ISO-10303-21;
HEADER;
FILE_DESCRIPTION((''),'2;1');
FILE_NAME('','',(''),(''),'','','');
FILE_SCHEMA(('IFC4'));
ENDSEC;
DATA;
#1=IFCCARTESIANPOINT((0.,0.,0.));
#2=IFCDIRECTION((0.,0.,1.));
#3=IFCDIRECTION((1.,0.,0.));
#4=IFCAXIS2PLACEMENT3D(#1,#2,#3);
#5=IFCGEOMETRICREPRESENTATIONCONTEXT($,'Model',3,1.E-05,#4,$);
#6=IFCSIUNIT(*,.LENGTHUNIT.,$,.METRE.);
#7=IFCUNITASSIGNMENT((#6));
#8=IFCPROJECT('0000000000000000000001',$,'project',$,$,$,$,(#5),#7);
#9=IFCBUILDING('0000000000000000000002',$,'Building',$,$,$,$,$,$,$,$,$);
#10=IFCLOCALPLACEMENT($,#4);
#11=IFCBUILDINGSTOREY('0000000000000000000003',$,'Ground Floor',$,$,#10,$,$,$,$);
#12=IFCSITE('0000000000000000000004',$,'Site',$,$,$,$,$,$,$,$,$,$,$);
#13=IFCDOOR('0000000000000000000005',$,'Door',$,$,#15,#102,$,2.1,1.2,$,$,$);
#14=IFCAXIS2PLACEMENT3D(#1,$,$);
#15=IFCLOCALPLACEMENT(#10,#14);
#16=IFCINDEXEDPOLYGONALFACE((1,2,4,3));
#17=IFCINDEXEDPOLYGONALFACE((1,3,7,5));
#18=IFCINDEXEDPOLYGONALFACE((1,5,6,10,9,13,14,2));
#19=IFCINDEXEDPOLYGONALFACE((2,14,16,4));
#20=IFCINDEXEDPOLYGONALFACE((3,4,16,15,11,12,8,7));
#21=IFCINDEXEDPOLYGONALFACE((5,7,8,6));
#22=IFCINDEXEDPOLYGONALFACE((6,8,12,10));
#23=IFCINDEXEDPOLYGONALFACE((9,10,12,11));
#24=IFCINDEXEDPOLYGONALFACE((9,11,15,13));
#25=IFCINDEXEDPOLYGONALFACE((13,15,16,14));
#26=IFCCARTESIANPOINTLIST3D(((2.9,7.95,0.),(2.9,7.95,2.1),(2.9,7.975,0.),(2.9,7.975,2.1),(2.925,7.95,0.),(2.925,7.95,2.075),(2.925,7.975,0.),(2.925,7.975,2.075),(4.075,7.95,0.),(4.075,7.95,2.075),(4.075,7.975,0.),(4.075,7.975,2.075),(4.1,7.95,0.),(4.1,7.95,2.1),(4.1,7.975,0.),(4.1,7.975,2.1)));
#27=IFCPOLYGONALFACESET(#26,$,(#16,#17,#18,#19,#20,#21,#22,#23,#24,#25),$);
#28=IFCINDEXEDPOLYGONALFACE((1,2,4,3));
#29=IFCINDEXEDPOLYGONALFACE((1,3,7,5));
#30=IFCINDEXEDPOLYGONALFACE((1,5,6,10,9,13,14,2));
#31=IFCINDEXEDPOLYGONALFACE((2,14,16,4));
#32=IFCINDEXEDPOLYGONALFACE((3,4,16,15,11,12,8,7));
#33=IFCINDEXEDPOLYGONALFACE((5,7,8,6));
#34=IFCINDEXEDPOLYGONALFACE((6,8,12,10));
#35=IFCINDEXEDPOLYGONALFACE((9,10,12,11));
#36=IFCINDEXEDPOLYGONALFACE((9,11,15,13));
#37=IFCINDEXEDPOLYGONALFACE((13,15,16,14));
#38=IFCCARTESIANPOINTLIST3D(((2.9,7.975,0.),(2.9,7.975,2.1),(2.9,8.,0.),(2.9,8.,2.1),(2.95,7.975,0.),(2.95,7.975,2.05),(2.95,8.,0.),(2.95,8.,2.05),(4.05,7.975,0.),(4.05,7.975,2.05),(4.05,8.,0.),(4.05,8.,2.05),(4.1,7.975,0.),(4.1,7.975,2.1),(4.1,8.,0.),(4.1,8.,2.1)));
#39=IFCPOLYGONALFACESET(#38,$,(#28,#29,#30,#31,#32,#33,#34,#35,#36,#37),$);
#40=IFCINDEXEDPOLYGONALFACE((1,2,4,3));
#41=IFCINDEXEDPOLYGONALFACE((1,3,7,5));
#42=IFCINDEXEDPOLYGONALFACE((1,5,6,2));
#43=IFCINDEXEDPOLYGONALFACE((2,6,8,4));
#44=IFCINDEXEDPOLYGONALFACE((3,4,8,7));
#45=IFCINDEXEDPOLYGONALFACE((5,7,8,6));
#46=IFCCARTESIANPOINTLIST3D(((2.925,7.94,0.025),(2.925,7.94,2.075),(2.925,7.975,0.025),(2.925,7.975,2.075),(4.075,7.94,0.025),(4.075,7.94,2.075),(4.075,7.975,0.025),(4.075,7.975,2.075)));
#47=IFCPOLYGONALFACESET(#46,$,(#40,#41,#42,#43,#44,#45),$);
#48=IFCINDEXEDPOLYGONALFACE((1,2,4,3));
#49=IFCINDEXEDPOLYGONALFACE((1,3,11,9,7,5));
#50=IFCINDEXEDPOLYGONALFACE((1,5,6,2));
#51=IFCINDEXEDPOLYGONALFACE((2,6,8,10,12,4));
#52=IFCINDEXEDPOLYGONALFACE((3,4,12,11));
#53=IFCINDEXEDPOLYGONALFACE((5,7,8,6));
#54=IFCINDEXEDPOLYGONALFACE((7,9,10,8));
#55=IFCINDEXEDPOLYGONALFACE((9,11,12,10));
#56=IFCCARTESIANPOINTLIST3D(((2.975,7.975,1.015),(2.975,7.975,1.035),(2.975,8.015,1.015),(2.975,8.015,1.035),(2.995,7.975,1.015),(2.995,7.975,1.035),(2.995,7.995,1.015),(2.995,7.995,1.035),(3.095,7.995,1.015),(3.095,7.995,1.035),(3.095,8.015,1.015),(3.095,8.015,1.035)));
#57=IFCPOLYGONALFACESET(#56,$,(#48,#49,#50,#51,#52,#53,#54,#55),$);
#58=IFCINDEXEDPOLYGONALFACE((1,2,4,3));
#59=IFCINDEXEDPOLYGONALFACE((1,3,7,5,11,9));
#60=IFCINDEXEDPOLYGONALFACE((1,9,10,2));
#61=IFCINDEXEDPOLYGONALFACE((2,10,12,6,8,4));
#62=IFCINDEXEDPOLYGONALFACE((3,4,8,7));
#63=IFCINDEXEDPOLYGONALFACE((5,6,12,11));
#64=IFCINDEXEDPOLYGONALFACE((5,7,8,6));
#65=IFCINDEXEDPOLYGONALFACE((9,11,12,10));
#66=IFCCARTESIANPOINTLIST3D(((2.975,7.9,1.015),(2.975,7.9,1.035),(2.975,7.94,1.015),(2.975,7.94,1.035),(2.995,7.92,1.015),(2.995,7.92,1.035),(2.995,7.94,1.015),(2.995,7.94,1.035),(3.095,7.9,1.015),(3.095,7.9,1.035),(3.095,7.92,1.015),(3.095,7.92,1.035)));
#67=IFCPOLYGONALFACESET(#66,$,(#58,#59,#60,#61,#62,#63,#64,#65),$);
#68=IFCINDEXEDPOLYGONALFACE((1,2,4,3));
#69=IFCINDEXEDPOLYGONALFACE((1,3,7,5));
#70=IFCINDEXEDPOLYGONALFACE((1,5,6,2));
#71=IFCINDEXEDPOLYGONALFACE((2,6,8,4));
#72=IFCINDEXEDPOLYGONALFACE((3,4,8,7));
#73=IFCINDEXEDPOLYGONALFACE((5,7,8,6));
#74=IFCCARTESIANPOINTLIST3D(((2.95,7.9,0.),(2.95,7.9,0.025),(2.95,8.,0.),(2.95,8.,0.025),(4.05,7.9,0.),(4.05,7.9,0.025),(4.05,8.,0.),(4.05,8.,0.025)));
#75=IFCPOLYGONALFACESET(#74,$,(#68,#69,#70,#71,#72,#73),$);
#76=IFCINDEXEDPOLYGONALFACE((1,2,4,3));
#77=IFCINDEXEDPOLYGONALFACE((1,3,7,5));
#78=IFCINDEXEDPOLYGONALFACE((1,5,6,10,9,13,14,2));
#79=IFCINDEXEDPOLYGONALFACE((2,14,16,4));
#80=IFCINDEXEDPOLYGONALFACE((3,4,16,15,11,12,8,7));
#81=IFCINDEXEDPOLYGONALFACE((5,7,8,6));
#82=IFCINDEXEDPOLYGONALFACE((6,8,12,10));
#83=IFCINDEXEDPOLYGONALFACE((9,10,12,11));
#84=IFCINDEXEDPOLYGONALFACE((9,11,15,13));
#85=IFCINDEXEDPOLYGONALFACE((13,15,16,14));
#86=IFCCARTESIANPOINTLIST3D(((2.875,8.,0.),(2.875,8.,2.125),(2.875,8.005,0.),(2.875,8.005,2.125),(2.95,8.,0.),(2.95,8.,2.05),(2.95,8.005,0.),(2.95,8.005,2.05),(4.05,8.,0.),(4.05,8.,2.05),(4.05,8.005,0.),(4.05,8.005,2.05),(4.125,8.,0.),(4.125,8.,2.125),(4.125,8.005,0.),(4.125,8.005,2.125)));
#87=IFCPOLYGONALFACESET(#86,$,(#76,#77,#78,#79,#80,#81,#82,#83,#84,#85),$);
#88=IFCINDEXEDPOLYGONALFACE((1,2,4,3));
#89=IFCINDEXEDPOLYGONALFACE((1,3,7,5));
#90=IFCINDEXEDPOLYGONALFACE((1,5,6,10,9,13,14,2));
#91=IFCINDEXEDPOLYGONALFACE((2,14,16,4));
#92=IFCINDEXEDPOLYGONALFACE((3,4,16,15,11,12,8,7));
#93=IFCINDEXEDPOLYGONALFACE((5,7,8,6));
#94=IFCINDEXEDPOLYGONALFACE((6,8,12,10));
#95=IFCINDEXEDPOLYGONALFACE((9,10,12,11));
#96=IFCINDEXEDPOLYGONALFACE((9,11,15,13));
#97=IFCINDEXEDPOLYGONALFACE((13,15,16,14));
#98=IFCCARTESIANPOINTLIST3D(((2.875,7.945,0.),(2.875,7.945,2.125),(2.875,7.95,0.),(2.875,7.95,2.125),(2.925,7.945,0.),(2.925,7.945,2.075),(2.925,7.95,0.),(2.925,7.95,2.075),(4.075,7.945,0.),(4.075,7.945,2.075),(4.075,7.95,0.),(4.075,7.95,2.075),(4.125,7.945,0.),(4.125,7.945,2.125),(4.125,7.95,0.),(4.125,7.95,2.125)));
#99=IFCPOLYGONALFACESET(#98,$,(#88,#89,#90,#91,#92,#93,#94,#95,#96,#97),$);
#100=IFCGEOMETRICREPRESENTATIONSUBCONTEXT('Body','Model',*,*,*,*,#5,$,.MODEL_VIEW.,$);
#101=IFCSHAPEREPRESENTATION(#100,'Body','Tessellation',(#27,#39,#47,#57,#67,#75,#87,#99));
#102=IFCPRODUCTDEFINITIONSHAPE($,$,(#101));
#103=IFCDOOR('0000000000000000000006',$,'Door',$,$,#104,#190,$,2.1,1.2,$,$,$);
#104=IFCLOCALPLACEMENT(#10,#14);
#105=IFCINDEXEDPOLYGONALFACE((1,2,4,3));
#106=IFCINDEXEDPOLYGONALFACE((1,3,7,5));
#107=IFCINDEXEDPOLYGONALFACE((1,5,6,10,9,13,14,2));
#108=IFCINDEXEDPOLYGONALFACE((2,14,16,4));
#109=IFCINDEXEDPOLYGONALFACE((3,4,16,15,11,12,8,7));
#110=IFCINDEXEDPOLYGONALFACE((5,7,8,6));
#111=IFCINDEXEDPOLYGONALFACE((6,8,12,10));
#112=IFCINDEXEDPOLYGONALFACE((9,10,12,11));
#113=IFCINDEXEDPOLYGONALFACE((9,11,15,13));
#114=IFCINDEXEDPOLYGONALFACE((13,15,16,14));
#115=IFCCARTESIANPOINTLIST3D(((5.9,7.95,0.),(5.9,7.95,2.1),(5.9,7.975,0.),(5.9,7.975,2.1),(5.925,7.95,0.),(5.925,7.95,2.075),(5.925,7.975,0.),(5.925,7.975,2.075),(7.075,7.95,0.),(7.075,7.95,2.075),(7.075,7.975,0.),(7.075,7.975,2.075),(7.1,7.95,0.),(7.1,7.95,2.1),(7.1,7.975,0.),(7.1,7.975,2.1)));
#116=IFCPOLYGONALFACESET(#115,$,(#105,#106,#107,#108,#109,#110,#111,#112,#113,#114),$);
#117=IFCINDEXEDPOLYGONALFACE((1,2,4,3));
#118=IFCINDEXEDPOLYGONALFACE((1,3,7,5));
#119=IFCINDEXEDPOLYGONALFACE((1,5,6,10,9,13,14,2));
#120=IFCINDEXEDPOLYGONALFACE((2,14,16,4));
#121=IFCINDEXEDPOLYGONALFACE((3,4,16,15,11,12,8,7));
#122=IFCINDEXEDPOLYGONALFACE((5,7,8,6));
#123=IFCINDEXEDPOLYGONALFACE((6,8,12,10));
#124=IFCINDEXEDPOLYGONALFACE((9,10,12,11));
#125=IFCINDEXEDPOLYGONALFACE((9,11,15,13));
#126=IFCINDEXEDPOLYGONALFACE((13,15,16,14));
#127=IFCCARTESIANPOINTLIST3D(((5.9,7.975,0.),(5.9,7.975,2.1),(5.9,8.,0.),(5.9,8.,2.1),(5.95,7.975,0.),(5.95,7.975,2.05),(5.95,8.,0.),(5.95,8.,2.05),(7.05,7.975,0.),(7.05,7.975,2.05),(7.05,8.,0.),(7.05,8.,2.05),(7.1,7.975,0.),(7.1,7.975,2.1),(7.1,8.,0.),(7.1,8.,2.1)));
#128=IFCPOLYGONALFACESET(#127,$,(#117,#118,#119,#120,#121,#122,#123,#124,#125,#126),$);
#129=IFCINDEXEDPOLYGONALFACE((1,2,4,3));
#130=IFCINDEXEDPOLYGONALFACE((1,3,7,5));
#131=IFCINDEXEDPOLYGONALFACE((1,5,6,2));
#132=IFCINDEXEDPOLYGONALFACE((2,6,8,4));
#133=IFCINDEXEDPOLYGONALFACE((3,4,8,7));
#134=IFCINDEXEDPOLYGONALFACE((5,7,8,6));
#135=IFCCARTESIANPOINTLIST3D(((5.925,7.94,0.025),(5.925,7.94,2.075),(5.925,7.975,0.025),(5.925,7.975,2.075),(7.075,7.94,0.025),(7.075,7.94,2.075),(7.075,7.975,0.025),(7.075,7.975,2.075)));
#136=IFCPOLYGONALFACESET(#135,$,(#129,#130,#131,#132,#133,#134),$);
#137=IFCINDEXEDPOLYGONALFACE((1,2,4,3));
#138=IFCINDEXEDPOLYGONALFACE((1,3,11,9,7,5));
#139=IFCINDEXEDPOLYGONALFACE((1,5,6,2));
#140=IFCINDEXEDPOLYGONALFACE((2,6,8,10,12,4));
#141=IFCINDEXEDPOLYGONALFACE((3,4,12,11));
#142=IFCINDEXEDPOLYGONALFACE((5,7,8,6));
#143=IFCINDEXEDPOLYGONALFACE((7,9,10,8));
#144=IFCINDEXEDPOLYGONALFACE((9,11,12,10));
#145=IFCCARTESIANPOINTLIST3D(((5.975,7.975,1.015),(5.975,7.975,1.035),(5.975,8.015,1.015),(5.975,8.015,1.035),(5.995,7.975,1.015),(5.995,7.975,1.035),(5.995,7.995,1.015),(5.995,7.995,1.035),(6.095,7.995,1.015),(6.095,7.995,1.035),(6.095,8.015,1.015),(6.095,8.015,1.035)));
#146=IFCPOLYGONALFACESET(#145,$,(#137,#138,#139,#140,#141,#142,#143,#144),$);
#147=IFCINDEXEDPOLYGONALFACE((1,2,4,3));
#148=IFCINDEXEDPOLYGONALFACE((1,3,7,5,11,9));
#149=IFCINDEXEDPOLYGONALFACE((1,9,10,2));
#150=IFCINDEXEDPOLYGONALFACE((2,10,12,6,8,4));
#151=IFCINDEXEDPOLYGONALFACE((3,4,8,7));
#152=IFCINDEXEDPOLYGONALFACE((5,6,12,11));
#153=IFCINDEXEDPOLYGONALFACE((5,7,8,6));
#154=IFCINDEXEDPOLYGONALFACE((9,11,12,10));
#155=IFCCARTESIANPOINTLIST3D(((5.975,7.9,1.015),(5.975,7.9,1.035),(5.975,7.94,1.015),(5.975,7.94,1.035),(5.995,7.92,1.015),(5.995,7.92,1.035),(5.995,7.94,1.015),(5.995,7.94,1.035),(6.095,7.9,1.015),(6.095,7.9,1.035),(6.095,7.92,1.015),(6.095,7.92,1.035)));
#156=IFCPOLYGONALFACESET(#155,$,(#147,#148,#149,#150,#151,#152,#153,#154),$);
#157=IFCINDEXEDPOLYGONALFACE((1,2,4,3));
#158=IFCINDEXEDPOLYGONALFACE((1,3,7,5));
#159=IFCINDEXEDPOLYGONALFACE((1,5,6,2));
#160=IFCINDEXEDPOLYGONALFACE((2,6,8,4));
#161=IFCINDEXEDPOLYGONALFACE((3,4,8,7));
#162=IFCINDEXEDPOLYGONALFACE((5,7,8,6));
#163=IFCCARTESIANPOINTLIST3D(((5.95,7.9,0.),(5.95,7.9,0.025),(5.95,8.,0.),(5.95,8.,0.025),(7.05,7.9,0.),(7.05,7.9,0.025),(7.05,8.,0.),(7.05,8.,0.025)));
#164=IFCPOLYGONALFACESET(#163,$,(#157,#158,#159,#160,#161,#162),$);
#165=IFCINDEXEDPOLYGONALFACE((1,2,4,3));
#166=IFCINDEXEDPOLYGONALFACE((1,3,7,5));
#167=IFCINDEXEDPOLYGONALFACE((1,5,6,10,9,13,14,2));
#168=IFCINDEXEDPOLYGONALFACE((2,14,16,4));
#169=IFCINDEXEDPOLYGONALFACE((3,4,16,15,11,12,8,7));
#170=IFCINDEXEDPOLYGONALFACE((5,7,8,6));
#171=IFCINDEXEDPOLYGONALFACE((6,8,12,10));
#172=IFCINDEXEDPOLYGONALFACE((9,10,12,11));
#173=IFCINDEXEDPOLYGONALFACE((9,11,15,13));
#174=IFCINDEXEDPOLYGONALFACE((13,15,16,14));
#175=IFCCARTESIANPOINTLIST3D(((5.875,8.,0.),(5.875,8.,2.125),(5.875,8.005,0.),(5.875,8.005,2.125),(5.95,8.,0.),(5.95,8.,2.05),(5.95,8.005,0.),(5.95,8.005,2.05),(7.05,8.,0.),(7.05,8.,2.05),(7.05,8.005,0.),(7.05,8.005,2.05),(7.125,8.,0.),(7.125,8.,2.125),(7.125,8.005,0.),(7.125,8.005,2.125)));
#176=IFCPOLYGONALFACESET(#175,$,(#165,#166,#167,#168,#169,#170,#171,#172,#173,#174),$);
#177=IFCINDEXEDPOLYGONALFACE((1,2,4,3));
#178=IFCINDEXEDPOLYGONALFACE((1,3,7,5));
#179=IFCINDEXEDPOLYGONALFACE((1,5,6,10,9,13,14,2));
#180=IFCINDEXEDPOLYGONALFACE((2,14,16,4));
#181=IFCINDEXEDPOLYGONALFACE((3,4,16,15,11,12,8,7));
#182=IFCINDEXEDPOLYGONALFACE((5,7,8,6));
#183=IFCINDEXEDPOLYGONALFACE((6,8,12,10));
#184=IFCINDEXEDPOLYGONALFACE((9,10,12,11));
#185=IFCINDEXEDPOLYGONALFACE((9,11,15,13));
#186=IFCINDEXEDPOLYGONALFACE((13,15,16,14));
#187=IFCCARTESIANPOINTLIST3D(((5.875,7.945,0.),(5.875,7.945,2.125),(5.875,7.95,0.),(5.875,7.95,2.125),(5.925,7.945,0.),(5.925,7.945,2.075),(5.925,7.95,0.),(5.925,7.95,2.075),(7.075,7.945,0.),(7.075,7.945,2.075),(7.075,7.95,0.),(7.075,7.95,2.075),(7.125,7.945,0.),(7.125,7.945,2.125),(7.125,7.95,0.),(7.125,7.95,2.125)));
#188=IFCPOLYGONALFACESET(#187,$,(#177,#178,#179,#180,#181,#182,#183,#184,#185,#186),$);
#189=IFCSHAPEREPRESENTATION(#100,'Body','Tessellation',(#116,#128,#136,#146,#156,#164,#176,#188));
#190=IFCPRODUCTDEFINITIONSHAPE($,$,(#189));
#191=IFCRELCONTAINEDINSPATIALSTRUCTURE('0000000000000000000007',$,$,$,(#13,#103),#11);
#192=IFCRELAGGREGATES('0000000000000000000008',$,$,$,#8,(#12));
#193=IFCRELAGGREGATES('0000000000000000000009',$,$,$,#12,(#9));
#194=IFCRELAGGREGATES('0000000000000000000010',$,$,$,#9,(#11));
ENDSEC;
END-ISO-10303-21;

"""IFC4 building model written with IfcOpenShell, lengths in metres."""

from ifc_helpers import new_model, si_unit, frame, origin_with_axes, place, context, subcontext, project, spatial, line, indexed_curve, outline, extrude, element, save


model = new_model("IFC4")

# Units and contexts
model_context = context("Model", 3, precision=1e-05, world=origin_with_axes())
body_context = subcontext(model_context, "Body", "Model", "MODEL_VIEW")
ifc_project = project(units=[si_unit("LENGTHUNIT", "METRE")], contexts=[model_context])

# Site, building, storey
site = spatial("IfcSite", under=ifc_project, Name="Site")
building = spatial("IfcBuilding", under=site, Name="Building")
storey_placement = place(None, origin_with_axes())
storey = spatial("IfcBuildingStorey", under=building, at=storey_placement, Name="Ground Floor")

# Doors
door_1_placement = place(storey_placement, frame((4.1, 8.0, 0.0), z_axis=(0.0, 0.0, 1.0), x_axis=(-1.0, 0.0, 0.0)))
element("IfcDoor", 1, at=door_1_placement, inside=storey, Name="Door", OverallHeight=2.1, OverallWidth=1.2, context=body_context, shape_type="SweptSolid", body=[
    extrude(outline(indexed_curve([(0.0, 0.0), (0.0, 2.1), (1.2, 2.1), (1.2, 0.0), (1.175, 0.0), (1.175, 2.075), (0.025, 2.075), (0.025, 0.0)], segments=[line(1, 2, 3, 4, 5, 6, 7, 8, 1)])), frame((0.0, 0.025, 0.0), z_axis=(0.0, -1.0, 0.0), x_axis=(1.0, 0.0, 0.0)), (0.0, 0.0, -1.0), 0.025),
    extrude(outline(indexed_curve([(0.0, 0.0), (0.0, 2.1), (1.2, 2.1), (1.2, 0.0), (1.15, 0.0), (1.15, 2.05), (0.05, 2.05), (0.05, 0.0)], segments=[line(1, 2, 3, 4, 5, 6, 7, 8, 1)])), frame((0.0, 0.0, 0.0), z_axis=(0.0, -1.0, 0.0), x_axis=(1.0, 0.0, 0.0)), (0.0, 0.0, -1.0), 0.025),
    extrude(outline(indexed_curve([(0.0, 0.0), (1.15, 0.0), (1.15, 0.035), (0.0, 0.035)], segments=[line(1, 2, 3, 4, 1)])), frame((0.025, 0.025, 0.025), z_axis=(0.0, 0.0, 1.0), x_axis=(1.0, 0.0, 0.0)), (0.0, 0.0, 1.0), 2.05),
    extrude(outline(indexed_curve([(0.0, 0.0), (0.0, -0.04), (-0.12, -0.04), (-0.12, -0.02), (-0.02, -0.02), (-0.02, 0.0)], segments=[line(1, 2, 3, 4, 5, 6, 1)])), frame((1.125, 0.025, 1.015), z_axis=(0.0, 0.0, 1.0), x_axis=(1.0, 0.0, 0.0)), (0.0, 0.0, 1.0), 0.02),
    extrude(outline(indexed_curve([(0.0, 0.0), (0.0, 0.04), (-0.12, 0.04), (-0.12, 0.02), (-0.02, 0.02), (-0.02, 0.0)], segments=[line(1, 2, 3, 4, 5, 6, 1)])), frame((1.125, 0.06, 1.015), z_axis=(0.0, 0.0, 1.0), x_axis=(1.0, 0.0, 0.0)), (0.0, 0.0, 1.0), 0.02),
    extrude(outline(indexed_curve([(0.0, 0.0), (1.1, 0.0), (1.1, 0.1), (0.0, 0.1)], segments=[line(1, 2, 3, 4, 1)])), frame((0.05, 0.0, 0.0), z_axis=(0.0, 0.0, 1.0), x_axis=(1.0, 0.0, 0.0)), (0.0, 0.0, 1.0), 0.025),
    extrude(outline(indexed_curve([(0.0, 0.0), (0.0, 2.125), (1.25, 2.125), (1.25, 0.0), (1.175, 0.0), (1.175, 2.05), (0.075, 2.05), (0.075, 0.0)], segments=[line(1, 2, 3, 4, 5, 6, 7, 8, 1)])), frame((-0.025, -0.005, 0.0), z_axis=(0.0, -1.0, 0.0), x_axis=(1.0, 0.0, 0.0)), (0.0, 0.0, -1.0), 0.005),
    extrude(outline(indexed_curve([(0.0, 0.0), (0.0, 2.125), (1.25, 2.125), (1.25, 0.0), (1.2, 0.0), (1.2, 2.075), (0.05, 2.075), (0.05, 0.0)], segments=[line(1, 2, 3, 4, 5, 6, 7, 8, 1)])), frame((-0.025, 0.05, 0.0), z_axis=(0.0, -1.0, 0.0), x_axis=(1.0, 0.0, 0.0)), (0.0, 0.0, -1.0), 0.005),
])
door_2_placement = place(storey_placement, frame((7.1, 8.0, 0.0), z_axis=(0.0, 0.0, 1.0), x_axis=(-1.0, 0.0, 0.0)))
element("IfcDoor", 2, at=door_2_placement, inside=storey, Name="Door", OverallHeight=2.1, OverallWidth=1.2, context=body_context, shape_type="SweptSolid", body=[
    extrude(outline(indexed_curve([(0.0, 0.0), (0.0, 2.1), (1.2, 2.1), (1.2, 0.0), (1.175, 0.0), (1.175, 2.075), (0.025, 2.075), (0.025, 0.0)], segments=[line(1, 2, 3, 4, 5, 6, 7, 8, 1)])), frame((0.0, 0.025, 0.0), z_axis=(0.0, -1.0, 0.0), x_axis=(1.0, 0.0, 0.0)), (0.0, 0.0, -1.0), 0.025),
    extrude(outline(indexed_curve([(0.0, 0.0), (0.0, 2.1), (1.2, 2.1), (1.2, 0.0), (1.15, 0.0), (1.15, 2.05), (0.05, 2.05), (0.05, 0.0)], segments=[line(1, 2, 3, 4, 5, 6, 7, 8, 1)])), frame((0.0, 0.0, 0.0), z_axis=(0.0, -1.0, 0.0), x_axis=(1.0, 0.0, 0.0)), (0.0, 0.0, -1.0), 0.025),
    extrude(outline(indexed_curve([(0.0, 0.0), (1.15, 0.0), (1.15, 0.035), (0.0, 0.035)], segments=[line(1, 2, 3, 4, 1)])), frame((0.025, 0.025, 0.025), z_axis=(0.0, 0.0, 1.0), x_axis=(1.0, 0.0, 0.0)), (0.0, 0.0, 1.0), 2.05),
    extrude(outline(indexed_curve([(0.0, 0.0), (0.0, -0.04), (-0.12, -0.04), (-0.12, -0.02), (-0.02, -0.02), (-0.02, 0.0)], segments=[line(1, 2, 3, 4, 5, 6, 1)])), frame((1.125, 0.025, 1.015), z_axis=(0.0, 0.0, 1.0), x_axis=(1.0, 0.0, 0.0)), (0.0, 0.0, 1.0), 0.02),
    extrude(outline(indexed_curve([(0.0, 0.0), (0.0, 0.04), (-0.12, 0.04), (-0.12, 0.02), (-0.02, 0.02), (-0.02, 0.0)], segments=[line(1, 2, 3, 4, 5, 6, 1)])), frame((1.125, 0.06, 1.015), z_axis=(0.0, 0.0, 1.0), x_axis=(1.0, 0.0, 0.0)), (0.0, 0.0, 1.0), 0.02),
    extrude(outline(indexed_curve([(0.0, 0.0), (1.1, 0.0), (1.1, 0.1), (0.0, 0.1)], segments=[line(1, 2, 3, 4, 1)])), frame((0.05, 0.0, 0.0), z_axis=(0.0, 0.0, 1.0), x_axis=(1.0, 0.0, 0.0)), (0.0, 0.0, 1.0), 0.025),
    extrude(outline(indexed_curve([(0.0, 0.0), (0.0, 2.125), (1.25, 2.125), (1.25, 0.0), (1.175, 0.0), (1.175, 2.05), (0.075, 2.05), (0.075, 0.0)], segments=[line(1, 2, 3, 4, 5, 6, 7, 8, 1)])), frame((-0.025, -0.005, 0.0), z_axis=(0.0, -1.0, 0.0), x_axis=(1.0, 0.0, 0.0)), (0.0, 0.0, -1.0), 0.005),
    extrude(outline(indexed_curve([(0.0, 0.0), (0.0, 2.125), (1.25, 2.125), (1.25, 0.0), (1.2, 0.0), (1.2, 2.075), (0.05, 2.075), (0.05, 0.0)], segments=[line(1, 2, 3, 4, 5, 6, 7, 8, 1)])), frame((-0.025, 0.05, 0.0), z_axis=(0.0, -1.0, 0.0), x_axis=(1.0, 0.0, 0.0)), (0.0, 0.0, -1.0), 0.005),
])

save(model, "model.ifc")
